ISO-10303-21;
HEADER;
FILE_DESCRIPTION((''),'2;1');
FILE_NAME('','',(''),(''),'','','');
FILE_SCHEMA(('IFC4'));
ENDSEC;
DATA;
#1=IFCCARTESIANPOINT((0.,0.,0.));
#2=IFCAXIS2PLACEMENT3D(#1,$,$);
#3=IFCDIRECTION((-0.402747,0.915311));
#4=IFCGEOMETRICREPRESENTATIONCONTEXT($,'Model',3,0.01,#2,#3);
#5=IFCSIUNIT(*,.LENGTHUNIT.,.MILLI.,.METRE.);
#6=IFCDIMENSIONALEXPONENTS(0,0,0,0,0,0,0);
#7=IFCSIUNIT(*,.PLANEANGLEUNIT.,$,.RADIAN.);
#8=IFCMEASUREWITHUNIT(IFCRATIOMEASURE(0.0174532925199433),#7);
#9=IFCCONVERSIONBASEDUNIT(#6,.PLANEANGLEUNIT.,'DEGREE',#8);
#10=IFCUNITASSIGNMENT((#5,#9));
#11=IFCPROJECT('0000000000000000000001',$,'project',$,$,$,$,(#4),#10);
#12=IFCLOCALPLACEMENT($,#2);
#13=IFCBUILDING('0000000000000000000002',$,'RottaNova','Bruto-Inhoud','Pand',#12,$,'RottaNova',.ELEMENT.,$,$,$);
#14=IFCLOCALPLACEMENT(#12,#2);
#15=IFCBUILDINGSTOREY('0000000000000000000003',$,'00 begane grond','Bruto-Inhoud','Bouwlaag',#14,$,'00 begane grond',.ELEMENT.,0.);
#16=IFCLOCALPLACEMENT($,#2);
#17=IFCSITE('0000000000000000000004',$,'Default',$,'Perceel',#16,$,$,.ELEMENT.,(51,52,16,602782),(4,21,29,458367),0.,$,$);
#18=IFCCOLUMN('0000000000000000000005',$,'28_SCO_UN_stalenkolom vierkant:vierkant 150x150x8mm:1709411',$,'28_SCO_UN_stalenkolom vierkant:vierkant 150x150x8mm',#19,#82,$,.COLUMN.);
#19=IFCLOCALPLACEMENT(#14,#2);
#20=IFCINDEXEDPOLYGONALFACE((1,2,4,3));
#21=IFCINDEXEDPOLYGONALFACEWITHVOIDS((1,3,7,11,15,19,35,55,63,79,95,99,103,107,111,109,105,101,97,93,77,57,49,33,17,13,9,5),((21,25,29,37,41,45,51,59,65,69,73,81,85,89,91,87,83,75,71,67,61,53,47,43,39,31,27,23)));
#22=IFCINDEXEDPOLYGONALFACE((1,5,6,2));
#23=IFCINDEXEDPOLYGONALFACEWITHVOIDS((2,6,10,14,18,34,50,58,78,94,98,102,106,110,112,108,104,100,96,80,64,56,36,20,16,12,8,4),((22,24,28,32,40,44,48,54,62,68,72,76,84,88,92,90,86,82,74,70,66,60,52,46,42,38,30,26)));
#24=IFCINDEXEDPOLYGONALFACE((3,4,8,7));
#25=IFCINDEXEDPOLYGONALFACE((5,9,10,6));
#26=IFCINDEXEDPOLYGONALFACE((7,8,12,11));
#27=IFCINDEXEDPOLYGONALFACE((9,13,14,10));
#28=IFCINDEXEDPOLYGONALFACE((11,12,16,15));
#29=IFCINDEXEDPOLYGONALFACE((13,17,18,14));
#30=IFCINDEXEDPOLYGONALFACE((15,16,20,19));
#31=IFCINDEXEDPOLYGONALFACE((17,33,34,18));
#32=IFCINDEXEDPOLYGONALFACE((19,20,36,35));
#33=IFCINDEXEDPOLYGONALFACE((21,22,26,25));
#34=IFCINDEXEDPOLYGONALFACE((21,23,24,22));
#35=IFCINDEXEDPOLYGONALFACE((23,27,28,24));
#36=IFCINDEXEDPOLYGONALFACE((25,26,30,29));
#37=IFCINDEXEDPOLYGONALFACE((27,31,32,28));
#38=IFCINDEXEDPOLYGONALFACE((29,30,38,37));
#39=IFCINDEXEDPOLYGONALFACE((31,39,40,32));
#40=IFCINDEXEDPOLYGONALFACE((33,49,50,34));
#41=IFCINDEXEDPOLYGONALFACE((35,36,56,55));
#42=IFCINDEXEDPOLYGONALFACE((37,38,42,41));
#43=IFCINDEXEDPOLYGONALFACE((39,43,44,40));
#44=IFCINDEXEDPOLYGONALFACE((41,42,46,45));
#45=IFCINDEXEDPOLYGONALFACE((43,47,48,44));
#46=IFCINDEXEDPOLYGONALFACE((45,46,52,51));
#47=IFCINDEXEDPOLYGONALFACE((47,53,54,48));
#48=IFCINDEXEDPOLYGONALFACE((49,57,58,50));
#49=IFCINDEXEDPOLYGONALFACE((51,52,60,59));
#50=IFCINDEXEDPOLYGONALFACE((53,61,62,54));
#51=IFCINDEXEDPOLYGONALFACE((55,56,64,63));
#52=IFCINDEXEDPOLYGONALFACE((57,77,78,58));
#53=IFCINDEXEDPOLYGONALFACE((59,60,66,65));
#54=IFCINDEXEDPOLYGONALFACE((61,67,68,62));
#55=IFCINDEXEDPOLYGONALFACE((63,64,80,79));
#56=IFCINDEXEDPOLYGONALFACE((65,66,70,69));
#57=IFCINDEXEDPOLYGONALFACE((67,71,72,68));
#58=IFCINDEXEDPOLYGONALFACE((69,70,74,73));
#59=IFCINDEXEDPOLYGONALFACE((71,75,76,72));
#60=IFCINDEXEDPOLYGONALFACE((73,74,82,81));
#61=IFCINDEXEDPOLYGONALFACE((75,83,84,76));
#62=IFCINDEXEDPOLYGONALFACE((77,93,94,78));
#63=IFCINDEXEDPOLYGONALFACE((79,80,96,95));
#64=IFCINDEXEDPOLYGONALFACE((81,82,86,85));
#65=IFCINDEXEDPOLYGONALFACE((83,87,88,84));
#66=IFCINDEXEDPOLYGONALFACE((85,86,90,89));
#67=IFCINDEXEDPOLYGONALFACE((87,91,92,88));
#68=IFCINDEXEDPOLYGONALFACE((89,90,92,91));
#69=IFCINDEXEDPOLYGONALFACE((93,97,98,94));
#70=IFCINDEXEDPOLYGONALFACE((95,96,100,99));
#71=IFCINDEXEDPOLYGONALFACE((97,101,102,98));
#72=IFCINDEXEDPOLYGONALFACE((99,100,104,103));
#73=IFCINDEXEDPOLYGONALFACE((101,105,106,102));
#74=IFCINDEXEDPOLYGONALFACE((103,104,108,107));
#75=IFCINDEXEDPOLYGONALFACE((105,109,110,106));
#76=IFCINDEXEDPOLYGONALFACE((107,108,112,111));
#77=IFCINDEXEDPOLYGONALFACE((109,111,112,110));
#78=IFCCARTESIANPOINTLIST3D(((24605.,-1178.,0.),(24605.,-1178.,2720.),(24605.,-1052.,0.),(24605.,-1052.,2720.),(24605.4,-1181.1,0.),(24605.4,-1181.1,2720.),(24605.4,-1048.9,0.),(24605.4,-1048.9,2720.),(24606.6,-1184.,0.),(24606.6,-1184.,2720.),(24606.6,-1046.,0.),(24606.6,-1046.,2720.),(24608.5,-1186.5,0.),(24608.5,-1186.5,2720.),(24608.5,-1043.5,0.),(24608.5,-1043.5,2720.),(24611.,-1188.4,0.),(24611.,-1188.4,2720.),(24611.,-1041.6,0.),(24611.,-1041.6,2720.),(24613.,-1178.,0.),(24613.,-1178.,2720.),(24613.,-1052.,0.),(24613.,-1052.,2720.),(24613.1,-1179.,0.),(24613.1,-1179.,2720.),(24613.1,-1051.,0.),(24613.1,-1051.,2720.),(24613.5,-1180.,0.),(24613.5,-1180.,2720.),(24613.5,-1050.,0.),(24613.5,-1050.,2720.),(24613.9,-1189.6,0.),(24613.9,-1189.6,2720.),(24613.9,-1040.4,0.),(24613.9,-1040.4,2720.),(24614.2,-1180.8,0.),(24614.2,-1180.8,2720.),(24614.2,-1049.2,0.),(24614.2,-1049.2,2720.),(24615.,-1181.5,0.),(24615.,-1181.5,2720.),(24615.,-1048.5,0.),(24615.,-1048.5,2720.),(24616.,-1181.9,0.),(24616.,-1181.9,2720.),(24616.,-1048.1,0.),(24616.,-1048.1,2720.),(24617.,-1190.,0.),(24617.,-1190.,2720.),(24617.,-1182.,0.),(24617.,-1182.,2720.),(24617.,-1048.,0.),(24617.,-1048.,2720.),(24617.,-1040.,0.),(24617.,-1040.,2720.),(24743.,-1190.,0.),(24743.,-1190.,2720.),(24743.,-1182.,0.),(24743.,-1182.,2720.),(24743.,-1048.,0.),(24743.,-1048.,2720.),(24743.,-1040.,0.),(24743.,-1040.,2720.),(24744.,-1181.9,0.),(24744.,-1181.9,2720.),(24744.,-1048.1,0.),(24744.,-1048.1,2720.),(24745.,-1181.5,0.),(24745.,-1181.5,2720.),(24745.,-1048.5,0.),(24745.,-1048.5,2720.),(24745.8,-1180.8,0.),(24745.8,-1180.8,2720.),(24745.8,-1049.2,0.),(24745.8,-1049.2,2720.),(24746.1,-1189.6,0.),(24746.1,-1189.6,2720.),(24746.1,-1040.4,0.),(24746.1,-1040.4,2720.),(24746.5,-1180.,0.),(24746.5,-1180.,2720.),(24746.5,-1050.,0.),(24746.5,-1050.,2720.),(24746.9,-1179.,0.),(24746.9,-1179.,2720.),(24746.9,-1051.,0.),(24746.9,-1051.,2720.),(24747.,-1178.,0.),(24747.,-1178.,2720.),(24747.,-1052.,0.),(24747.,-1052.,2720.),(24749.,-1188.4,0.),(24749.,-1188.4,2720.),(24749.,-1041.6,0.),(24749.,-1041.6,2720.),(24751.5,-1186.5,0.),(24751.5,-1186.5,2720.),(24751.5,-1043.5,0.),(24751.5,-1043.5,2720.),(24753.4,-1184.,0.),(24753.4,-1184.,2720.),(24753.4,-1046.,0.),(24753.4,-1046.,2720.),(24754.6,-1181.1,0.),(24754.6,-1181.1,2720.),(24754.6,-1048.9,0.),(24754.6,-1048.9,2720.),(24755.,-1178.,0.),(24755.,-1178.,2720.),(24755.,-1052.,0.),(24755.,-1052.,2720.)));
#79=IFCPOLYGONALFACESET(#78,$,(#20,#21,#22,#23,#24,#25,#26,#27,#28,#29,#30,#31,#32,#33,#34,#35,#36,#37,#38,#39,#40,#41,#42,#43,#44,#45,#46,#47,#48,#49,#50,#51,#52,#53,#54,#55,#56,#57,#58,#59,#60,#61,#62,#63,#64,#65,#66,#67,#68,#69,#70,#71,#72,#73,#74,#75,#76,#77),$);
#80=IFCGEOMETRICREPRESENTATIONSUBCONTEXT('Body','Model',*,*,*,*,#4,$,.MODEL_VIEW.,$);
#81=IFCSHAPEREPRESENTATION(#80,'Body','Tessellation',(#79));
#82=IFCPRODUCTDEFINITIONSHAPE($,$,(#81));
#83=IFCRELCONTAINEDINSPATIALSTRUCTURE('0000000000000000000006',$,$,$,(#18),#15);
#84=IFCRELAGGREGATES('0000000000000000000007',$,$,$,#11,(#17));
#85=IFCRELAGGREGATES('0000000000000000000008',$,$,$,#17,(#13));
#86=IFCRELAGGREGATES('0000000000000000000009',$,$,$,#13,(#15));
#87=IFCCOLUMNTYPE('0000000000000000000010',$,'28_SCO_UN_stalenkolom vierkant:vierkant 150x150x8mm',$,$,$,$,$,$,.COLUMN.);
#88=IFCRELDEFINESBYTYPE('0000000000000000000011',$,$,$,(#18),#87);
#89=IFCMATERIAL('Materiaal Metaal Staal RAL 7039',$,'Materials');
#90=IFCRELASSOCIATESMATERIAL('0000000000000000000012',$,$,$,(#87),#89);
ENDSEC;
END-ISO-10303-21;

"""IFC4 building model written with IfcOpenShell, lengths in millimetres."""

from ifc_helpers import new_model, entity, si_unit, converted_unit, direction, frame, frame_2d, origin, place, context, subcontext, project, spatial, polyline, circle_curve, parameter, trimmed, segment, composite_curve, outline, extrude, source, transform, mapped, material, material_profile, profile_set, type_object, type_shapes, element, save


model = new_model("IFC4")

# Units and contexts
model_context = context("Model", 3, precision=0.01, world=origin(), true_north=direction((-0.402747, 0.915311)))
body_context = subcontext(model_context, "Body", "Model", "MODEL_VIEW")
ifc_project = project(units=[si_unit("LENGTHUNIT", "METRE", prefix="MILLI"), converted_unit("PLANEANGLEUNIT", "DEGREE", entity("IfcRatioMeasure", 0.0174532925199433), si_unit("PLANEANGLEUNIT", "RADIAN"), dimensions=[0, 0, 0, 0, 0, 0, 0])], contexts=[model_context])

# Site, building, storey
site_placement = place(None, origin())
site = spatial("IfcSite", under=ifc_project, at=site_placement, Name="Default", ObjectType="Perceel", CompositionType="ELEMENT", RefLatitude=(51, 52, 16, 602782), RefLongitude=(4, 21, 29, 458367), RefElevation=0.0)
building_placement = place(None, origin())
building = spatial("IfcBuilding", under=site, at=building_placement, Name="RottaNova", Description="Bruto-Inhoud", ObjectType="Pand", LongName="RottaNova", CompositionType="ELEMENT")
storey_placement = place(building_placement, origin())
storey = spatial("IfcBuildingStorey", under=building, at=storey_placement, Name="00 begane grond", Description="Bruto-Inhoud", ObjectType="Bouwlaag", LongName="00 begane grond", CompositionType="ELEMENT", Elevation=0.0)

# Column
ifc_material_1 = material(Name="Materiaal Metaal Staal RAL 7039", Category="Materials")
ifc_material_profile = material_profile(ifc_material_1, outline(composite_curve([segment(trimmed(circle_curve(frame_2d((63.0, -63.0), x_axis=(1.0, 0.0)), 12.0), [parameter(270.0)], [parameter(360.0)], True, "PARAMETER"), True, "CONTINUOUS"), segment(polyline([(75.0, -63.0), (75.0, 63.0)]), True, "CONTINUOUS"), segment(trimmed(circle_curve(frame_2d((63.0, 63.0), x_axis=(1.0, 0.0)), 12.0), [parameter(360.0)], [parameter(90.0)], True, "PARAMETER"), True, "CONTINUOUS"), segment(polyline([(63.0, 75.0), (-63.0, 75.0)]), True, "CONTINUOUS"), segment(trimmed(circle_curve(frame_2d((-63.0, 63.0), x_axis=(1.0, 0.0)), 12.0), [parameter(90.0)], [parameter(180.0)], True, "PARAMETER"), True, "CONTINUOUS"), segment(polyline([(-75.0, 63.0), (-75.0, -63.0)]), True, "CONTINUOUS"), segment(trimmed(circle_curve(frame_2d((-63.0, -63.0), x_axis=(1.0, 0.0)), 12.0), [parameter(180.0)], [parameter(270.0)], True, "PARAMETER"), True, "CONTINUOUS"), segment(polyline([(-63.0, -75.0), (63.0, -75.0)]), True, "CONTINUOUS")], self_intersect=False), holes=[composite_curve([segment(polyline([(-67.0, -63.0), (-67.0, 63.0)]), True, "CONTINUOUS"), segment(trimmed(circle_curve(frame_2d((-63.0, 63.0), x_axis=(1.0, 0.0)), 4.0), [parameter(90.0)], [parameter(180.0)], True, "PARAMETER"), False, "CONTINUOUS"), segment(polyline([(-63.0, 67.0), (63.0, 67.0)]), True, "CONTINUOUS"), segment(trimmed(circle_curve(frame_2d((63.0, 63.0), x_axis=(1.0, 0.0)), 4.0), [parameter(0.0)], [parameter(90.0)], True, "PARAMETER"), False, "CONTINUOUS"), segment(polyline([(67.0, 63.0), (67.0, -63.0)]), True, "CONTINUOUS"), segment(trimmed(circle_curve(frame_2d((63.0, -63.0), x_axis=(1.0, 0.0)), 4.0), [parameter(270.0)], [parameter(0.0)], True, "PARAMETER"), False, "CONTINUOUS"), segment(polyline([(63.0, -67.0), (-63.0, -67.0)]), True, "CONTINUOUS"), segment(trimmed(circle_curve(frame_2d((-63.0, -63.0), x_axis=(1.0, 0.0)), 4.0), [parameter(180.0)], [parameter(270.0)], True, "PARAMETER"), False, "CONTINUOUS")], self_intersect=False)]), Name="vierkant 150x150x8mm")
ifc_profile_set = profile_set([ifc_material_profile], Name="vierkant 150x150x8mm")
column_type_1 = type_object("IfcColumnType", Name="28_SCO_UN_stalenkolom vierkant:vierkant 150x150x8mm", PredefinedType="COLUMN", material=ifc_profile_set)
shared_shape_1 = source(origin(), body_context, "Body", "SweptSolid", [
    extrude(outline(composite_curve([segment(trimmed(circle_curve(frame_2d((63.0, -63.0), x_axis=(1.0, 0.0)), 12.0), [parameter(270.0)], [parameter(360.0)], True, "PARAMETER"), True, "CONTINUOUS"), segment(polyline([(75.0, -63.0), (75.0, 63.0)]), True, "CONTINUOUS"), segment(trimmed(circle_curve(frame_2d((63.0, 63.0), x_axis=(1.0, 0.0)), 12.0), [parameter(360.0)], [parameter(90.0)], True, "PARAMETER"), True, "CONTINUOUS"), segment(polyline([(63.0, 75.0), (-63.0, 75.0)]), True, "CONTINUOUS"), segment(trimmed(circle_curve(frame_2d((-63.0, 63.0), x_axis=(1.0, 0.0)), 12.0), [parameter(90.0)], [parameter(180.0)], True, "PARAMETER"), True, "CONTINUOUS"), segment(polyline([(-75.0, 63.0), (-75.0, -63.0)]), True, "CONTINUOUS"), segment(trimmed(circle_curve(frame_2d((-63.0, -63.0), x_axis=(1.0, 0.0)), 12.0), [parameter(180.0)], [parameter(270.0)], True, "PARAMETER"), True, "CONTINUOUS"), segment(polyline([(-63.0, -75.0), (63.0, -75.0)]), True, "CONTINUOUS")], self_intersect=False), holes=[composite_curve([segment(polyline([(-67.0, -63.0), (-67.0, 63.0)]), True, "CONTINUOUS"), segment(trimmed(circle_curve(frame_2d((-63.0, 63.0), x_axis=(1.0, 0.0)), 4.0), [parameter(90.0)], [parameter(180.0)], True, "PARAMETER"), False, "CONTINUOUS"), segment(polyline([(-63.0, 67.0), (63.0, 67.0)]), True, "CONTINUOUS"), segment(trimmed(circle_curve(frame_2d((63.0, 63.0), x_axis=(1.0, 0.0)), 4.0), [parameter(0.0)], [parameter(90.0)], True, "PARAMETER"), False, "CONTINUOUS"), segment(polyline([(67.0, 63.0), (67.0, -63.0)]), True, "CONTINUOUS"), segment(trimmed(circle_curve(frame_2d((63.0, -63.0), x_axis=(1.0, 0.0)), 4.0), [parameter(270.0)], [parameter(0.0)], True, "PARAMETER"), False, "CONTINUOUS"), segment(polyline([(63.0, -67.0), (-63.0, -67.0)]), True, "CONTINUOUS"), segment(trimmed(circle_curve(frame_2d((-63.0, -63.0), x_axis=(1.0, 0.0)), 4.0), [parameter(180.0)], [parameter(270.0)], True, "PARAMETER"), False, "CONTINUOUS")], self_intersect=False)]), origin(), (0.0, 0.0, 1.0), 2720.0),
])
type_shapes(column_type_1, [shared_shape_1])
column_1_placement = place(storey_placement, frame((24680.0, -1115.0, 0.0)))
element("IfcColumn", 1, at=column_1_placement, inside=storey, type_object=column_type_1, Name="28_SCO_UN_stalenkolom vierkant:vierkant 150x150x8mm:1709411", ObjectType="28_SCO_UN_stalenkolom vierkant:vierkant 150x150x8mm", PredefinedType="COLUMN", context=body_context, shape_type="MappedRepresentation", body=[
    mapped(shared_shape_1, transform((0.0, 0.0, 0.0), scale=1.0)),
])

save(model, "model.ifc")
